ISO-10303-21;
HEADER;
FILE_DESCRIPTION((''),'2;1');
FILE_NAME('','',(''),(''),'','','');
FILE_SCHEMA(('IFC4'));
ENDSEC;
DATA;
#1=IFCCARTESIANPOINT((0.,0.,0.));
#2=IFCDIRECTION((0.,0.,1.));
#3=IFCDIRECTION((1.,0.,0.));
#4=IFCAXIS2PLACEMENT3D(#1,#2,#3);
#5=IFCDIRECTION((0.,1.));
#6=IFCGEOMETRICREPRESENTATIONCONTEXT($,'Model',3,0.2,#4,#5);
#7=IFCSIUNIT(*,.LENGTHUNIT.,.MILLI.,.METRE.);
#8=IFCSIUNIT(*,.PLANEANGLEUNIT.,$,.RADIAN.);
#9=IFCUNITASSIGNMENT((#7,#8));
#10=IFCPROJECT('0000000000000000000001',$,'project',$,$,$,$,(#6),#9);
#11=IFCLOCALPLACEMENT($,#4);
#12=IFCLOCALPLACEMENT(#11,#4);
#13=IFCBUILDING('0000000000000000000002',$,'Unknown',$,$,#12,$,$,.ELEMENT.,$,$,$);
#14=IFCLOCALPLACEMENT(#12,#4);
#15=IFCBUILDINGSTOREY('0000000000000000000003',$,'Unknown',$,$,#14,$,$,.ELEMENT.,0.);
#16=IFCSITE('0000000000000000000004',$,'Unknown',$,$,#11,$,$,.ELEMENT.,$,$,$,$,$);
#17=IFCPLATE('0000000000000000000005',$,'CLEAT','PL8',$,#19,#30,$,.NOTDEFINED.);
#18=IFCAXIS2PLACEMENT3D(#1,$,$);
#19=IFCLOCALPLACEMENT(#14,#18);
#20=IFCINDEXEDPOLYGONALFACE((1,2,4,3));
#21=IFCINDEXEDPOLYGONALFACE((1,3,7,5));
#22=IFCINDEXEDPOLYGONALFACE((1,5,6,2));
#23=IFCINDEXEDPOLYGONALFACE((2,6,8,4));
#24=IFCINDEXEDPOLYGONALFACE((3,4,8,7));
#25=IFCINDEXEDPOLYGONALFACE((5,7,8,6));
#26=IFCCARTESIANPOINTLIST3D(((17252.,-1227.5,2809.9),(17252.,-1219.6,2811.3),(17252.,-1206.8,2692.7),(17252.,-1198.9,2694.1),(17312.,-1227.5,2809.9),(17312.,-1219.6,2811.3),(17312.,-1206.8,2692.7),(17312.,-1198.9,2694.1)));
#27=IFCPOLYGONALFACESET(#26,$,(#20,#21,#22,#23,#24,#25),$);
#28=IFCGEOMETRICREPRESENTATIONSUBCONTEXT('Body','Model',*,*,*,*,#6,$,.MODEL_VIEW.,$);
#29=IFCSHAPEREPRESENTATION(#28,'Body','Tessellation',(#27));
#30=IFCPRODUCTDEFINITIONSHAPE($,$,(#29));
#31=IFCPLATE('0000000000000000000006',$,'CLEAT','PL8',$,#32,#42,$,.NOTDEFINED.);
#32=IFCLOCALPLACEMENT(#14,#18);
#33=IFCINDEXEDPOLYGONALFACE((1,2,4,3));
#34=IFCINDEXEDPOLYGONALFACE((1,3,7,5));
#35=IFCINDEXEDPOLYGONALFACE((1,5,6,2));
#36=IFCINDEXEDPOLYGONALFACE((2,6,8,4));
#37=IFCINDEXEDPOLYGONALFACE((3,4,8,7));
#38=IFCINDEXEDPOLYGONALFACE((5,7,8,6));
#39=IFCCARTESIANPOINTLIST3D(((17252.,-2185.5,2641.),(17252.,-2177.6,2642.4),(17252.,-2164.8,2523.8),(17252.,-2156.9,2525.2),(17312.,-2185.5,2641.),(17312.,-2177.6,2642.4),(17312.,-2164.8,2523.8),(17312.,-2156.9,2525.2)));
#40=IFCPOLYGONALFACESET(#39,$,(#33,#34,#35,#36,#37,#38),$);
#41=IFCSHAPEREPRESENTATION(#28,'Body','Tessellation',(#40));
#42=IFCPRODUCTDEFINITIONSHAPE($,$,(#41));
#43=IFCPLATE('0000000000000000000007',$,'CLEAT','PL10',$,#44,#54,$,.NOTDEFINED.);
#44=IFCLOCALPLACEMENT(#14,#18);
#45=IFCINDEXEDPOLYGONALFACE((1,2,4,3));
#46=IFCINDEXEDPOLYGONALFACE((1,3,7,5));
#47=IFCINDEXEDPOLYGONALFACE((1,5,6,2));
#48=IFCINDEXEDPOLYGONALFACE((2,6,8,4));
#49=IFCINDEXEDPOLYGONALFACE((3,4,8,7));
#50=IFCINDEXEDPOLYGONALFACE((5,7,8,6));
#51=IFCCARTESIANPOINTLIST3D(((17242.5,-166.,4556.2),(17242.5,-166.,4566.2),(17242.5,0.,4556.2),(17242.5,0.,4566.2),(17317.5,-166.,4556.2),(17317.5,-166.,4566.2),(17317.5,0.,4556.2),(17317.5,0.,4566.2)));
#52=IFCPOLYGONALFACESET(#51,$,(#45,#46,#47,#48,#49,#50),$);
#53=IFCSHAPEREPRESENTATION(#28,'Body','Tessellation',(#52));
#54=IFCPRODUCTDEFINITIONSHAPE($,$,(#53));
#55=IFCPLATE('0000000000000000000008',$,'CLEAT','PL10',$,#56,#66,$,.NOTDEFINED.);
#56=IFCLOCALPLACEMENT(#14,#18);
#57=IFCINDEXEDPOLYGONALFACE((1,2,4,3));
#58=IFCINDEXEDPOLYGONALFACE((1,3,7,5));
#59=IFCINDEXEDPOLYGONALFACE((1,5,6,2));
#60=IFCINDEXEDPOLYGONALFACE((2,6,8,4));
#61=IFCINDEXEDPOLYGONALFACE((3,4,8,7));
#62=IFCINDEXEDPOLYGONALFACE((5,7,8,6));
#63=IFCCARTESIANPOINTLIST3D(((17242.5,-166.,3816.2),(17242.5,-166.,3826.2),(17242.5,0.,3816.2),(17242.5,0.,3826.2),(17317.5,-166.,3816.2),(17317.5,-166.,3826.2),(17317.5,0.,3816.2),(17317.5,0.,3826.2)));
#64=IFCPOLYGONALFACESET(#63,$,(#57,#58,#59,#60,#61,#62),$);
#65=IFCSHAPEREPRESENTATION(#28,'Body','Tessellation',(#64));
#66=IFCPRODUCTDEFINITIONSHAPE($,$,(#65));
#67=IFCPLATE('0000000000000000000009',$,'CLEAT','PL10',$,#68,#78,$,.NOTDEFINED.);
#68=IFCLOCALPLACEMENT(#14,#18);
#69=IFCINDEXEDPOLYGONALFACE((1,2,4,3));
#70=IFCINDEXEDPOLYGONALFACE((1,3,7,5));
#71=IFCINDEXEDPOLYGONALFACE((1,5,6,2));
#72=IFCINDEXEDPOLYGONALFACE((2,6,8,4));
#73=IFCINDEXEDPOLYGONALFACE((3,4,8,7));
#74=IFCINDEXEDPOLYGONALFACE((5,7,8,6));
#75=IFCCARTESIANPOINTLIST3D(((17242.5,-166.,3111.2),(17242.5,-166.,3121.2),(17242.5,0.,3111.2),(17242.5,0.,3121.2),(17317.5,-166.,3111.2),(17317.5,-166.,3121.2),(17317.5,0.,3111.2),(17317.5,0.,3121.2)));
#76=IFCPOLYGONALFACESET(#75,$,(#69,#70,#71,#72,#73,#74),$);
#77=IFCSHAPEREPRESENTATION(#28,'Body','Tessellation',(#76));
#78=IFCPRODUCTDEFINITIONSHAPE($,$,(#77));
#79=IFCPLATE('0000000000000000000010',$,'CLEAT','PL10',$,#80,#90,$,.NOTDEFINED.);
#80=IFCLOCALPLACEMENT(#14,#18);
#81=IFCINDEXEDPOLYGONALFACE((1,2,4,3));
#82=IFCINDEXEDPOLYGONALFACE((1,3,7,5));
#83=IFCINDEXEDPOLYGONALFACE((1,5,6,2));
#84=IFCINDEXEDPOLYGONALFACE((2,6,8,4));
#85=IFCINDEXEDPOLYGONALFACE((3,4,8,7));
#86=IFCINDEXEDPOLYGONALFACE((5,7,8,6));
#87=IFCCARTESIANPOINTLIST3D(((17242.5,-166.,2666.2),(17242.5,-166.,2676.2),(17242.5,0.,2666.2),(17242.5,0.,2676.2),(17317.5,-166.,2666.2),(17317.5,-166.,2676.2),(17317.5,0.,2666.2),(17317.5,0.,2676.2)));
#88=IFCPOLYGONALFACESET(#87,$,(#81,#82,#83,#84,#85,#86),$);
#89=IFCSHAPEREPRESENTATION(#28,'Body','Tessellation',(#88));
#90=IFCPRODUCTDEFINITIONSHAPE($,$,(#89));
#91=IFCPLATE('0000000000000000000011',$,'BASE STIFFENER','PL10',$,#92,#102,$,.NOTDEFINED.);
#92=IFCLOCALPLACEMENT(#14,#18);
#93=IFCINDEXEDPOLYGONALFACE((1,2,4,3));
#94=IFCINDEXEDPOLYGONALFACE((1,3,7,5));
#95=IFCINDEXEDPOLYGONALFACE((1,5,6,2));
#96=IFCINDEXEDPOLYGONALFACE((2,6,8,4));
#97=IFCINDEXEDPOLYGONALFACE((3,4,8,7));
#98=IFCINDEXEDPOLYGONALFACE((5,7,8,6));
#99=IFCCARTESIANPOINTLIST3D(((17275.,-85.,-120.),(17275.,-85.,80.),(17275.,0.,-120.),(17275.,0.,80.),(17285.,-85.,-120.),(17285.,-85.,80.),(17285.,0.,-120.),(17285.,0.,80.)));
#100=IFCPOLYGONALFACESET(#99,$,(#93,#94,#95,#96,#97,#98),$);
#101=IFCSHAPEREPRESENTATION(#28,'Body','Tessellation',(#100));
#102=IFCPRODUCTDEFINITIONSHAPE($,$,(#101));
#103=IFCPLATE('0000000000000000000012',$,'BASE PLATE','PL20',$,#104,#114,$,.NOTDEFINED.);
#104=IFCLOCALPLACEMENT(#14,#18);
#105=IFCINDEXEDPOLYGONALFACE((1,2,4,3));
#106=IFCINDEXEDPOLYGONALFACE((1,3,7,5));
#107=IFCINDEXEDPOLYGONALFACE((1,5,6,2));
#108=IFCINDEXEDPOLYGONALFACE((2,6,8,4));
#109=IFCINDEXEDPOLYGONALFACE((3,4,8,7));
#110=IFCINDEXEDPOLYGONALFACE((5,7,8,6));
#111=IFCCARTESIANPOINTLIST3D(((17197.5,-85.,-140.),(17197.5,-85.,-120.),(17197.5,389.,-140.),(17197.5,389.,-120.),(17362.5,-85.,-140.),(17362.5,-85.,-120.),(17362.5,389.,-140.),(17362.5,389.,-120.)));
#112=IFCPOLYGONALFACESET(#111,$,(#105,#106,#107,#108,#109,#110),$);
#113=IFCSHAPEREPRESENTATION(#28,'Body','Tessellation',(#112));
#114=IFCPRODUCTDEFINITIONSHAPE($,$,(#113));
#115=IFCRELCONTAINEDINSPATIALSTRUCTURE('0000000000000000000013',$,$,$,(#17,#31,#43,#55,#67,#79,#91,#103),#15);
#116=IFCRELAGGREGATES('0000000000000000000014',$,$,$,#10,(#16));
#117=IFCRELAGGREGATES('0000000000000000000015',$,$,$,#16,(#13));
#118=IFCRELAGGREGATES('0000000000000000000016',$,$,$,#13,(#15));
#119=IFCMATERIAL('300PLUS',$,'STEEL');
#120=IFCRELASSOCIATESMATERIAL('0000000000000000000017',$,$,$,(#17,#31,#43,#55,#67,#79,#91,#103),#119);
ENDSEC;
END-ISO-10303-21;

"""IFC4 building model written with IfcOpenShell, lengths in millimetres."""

from ifc_helpers import new_model, si_unit, direction, frame, origin_with_axes, place, context, subcontext, project, spatial, line, indexed_curve, outline, extrude, material, element, save


model = new_model("IFC4")

# Units and contexts
model_context = context("Model", 3, precision=0.2, world=origin_with_axes(), true_north=direction((0.0, 1.0)))
body_context = subcontext(model_context, "Body", "Model", "MODEL_VIEW")
ifc_project = project(units=[si_unit("LENGTHUNIT", "METRE", prefix="MILLI"), si_unit("PLANEANGLEUNIT", "RADIAN")], contexts=[model_context])

# Site, building, storey
site_placement = place(None, origin_with_axes())
site = spatial("IfcSite", under=ifc_project, at=site_placement, Name="Unknown", CompositionType="ELEMENT")
building_placement = place(site_placement, origin_with_axes())
building = spatial("IfcBuilding", under=site, at=building_placement, Name="Unknown", CompositionType="ELEMENT")
storey_placement = place(building_placement, origin_with_axes())
storey = spatial("IfcBuildingStorey", under=building, at=storey_placement, Name="Unknown", CompositionType="ELEMENT", Elevation=0.0)

# Shared definitions
ifc_material_1 = material(Name="300PLUS", Category="STEEL")

# Plates
for number, where, z_axis, x_axis, name in (
    (1, (17312.0, -1202.9, 2693.4), (0.0, 0.984758, 0.173929), (-1.0, 0.0, 0.0), "CLEAT"),
    (2, (17312.0, -2160.9, 2524.5), (0.0, 0.984758, 0.173929), (-1.0, 0.0, 0.0), "CLEAT"),
):
    element("IfcPlate", number, at=place(storey_placement, frame(where, z_axis=z_axis, x_axis=x_axis)), inside=storey, material=ifc_material_1, Name=name, Description="PL8", PredefinedType="NOTDEFINED", context=body_context, shape_type="SolidModel", body=[
        extrude(outline(indexed_curve([(0.0, 0.0), (60.0, 0.0), (60.0, 119.0), (0.0, 119.0)], segments=[line(1, 2, 3, 4, 1)])), frame((0.0, 0.0, 4.0), z_axis=(0.0, 0.0, 1.0), x_axis=(1.0, 0.0, 0.0)), (0.0, 0.0, -1.0), 8.0),
    ])
for number, where, z_axis, x_axis, name in (
    (3, (17317.5, 0.0, 4561.2), (0.0, 0.0, 1.0), (-1.0, 0.0, 0.0), "CLEAT"),
    (4, (17317.5, 0.0, 3821.2), (0.0, 0.0, 1.0), (-1.0, 0.0, 0.0), "CLEAT"),
    (5, (17317.5, 0.0, 3116.2), (0.0, 0.0, 1.0), (-1.0, 0.0, 0.0), "CLEAT"),
    (6, (17317.5, 0.0, 2671.2), (0.0, 0.0, 1.0), (-1.0, 0.0, 0.0), "CLEAT"),
):
    element("IfcPlate", number, at=place(storey_placement, frame(where, z_axis=z_axis, x_axis=x_axis)), inside=storey, material=ifc_material_1, Name=name, Description="PL10", PredefinedType="NOTDEFINED", context=body_context, shape_type="SolidModel", body=[
        extrude(outline(indexed_curve([(0.0, 0.0), (75.0, 0.0), (75.0, 166.0), (0.0, 166.0)], segments=[line(1, 2, 3, 4, 1)])), frame((0.0, 0.0, 5.0), z_axis=(0.0, 0.0, 1.0), x_axis=(1.0, 0.0, 0.0)), (0.0, 0.0, -1.0), 10.0),
    ])
plate_1_placement = place(storey_placement, frame((17280.0, -85.0, -120.0), z_axis=(1.0, 0.0, 0.0), x_axis=(0.0, 1.0, 0.0)))
element("IfcPlate", 7, at=plate_1_placement, inside=storey, material=ifc_material_1, Name="BASE STIFFENER", Description="PL10", PredefinedType="NOTDEFINED", context=body_context, shape_type="SolidModel", body=[
    extrude(outline(indexed_curve([(0.0, 0.0), (85.0, 0.0), (85.0, 200.0), (0.0, 200.0)], segments=[line(1, 2, 3, 4, 1)])), frame((0.0, 0.0, 5.0), z_axis=(0.0, 0.0, 1.0), x_axis=(1.0, 0.0, 0.0)), (0.0, 0.0, -1.0), 10.0),
])
plate_2_placement = place(storey_placement, frame((17197.5, -85.0, -130.0), z_axis=(0.0, 0.0, 1.0), x_axis=(1.0, 0.0, 0.0)))
element("IfcPlate", 8, at=plate_2_placement, inside=storey, material=ifc_material_1, Name="BASE PLATE", Description="PL20", PredefinedType="NOTDEFINED", context=body_context, shape_type="SolidModel", body=[
    extrude(outline(indexed_curve([(0.0, 0.0), (165.0, 0.0), (165.0, 474.0), (0.0, 474.0)], segments=[line(1, 2, 3, 4, 1)])), frame((0.0, 0.0, 10.0), z_axis=(0.0, 0.0, 1.0), x_axis=(1.0, 0.0, 0.0)), (0.0, 0.0, -1.0), 20.0),
])

save(model, "model.ifc")
